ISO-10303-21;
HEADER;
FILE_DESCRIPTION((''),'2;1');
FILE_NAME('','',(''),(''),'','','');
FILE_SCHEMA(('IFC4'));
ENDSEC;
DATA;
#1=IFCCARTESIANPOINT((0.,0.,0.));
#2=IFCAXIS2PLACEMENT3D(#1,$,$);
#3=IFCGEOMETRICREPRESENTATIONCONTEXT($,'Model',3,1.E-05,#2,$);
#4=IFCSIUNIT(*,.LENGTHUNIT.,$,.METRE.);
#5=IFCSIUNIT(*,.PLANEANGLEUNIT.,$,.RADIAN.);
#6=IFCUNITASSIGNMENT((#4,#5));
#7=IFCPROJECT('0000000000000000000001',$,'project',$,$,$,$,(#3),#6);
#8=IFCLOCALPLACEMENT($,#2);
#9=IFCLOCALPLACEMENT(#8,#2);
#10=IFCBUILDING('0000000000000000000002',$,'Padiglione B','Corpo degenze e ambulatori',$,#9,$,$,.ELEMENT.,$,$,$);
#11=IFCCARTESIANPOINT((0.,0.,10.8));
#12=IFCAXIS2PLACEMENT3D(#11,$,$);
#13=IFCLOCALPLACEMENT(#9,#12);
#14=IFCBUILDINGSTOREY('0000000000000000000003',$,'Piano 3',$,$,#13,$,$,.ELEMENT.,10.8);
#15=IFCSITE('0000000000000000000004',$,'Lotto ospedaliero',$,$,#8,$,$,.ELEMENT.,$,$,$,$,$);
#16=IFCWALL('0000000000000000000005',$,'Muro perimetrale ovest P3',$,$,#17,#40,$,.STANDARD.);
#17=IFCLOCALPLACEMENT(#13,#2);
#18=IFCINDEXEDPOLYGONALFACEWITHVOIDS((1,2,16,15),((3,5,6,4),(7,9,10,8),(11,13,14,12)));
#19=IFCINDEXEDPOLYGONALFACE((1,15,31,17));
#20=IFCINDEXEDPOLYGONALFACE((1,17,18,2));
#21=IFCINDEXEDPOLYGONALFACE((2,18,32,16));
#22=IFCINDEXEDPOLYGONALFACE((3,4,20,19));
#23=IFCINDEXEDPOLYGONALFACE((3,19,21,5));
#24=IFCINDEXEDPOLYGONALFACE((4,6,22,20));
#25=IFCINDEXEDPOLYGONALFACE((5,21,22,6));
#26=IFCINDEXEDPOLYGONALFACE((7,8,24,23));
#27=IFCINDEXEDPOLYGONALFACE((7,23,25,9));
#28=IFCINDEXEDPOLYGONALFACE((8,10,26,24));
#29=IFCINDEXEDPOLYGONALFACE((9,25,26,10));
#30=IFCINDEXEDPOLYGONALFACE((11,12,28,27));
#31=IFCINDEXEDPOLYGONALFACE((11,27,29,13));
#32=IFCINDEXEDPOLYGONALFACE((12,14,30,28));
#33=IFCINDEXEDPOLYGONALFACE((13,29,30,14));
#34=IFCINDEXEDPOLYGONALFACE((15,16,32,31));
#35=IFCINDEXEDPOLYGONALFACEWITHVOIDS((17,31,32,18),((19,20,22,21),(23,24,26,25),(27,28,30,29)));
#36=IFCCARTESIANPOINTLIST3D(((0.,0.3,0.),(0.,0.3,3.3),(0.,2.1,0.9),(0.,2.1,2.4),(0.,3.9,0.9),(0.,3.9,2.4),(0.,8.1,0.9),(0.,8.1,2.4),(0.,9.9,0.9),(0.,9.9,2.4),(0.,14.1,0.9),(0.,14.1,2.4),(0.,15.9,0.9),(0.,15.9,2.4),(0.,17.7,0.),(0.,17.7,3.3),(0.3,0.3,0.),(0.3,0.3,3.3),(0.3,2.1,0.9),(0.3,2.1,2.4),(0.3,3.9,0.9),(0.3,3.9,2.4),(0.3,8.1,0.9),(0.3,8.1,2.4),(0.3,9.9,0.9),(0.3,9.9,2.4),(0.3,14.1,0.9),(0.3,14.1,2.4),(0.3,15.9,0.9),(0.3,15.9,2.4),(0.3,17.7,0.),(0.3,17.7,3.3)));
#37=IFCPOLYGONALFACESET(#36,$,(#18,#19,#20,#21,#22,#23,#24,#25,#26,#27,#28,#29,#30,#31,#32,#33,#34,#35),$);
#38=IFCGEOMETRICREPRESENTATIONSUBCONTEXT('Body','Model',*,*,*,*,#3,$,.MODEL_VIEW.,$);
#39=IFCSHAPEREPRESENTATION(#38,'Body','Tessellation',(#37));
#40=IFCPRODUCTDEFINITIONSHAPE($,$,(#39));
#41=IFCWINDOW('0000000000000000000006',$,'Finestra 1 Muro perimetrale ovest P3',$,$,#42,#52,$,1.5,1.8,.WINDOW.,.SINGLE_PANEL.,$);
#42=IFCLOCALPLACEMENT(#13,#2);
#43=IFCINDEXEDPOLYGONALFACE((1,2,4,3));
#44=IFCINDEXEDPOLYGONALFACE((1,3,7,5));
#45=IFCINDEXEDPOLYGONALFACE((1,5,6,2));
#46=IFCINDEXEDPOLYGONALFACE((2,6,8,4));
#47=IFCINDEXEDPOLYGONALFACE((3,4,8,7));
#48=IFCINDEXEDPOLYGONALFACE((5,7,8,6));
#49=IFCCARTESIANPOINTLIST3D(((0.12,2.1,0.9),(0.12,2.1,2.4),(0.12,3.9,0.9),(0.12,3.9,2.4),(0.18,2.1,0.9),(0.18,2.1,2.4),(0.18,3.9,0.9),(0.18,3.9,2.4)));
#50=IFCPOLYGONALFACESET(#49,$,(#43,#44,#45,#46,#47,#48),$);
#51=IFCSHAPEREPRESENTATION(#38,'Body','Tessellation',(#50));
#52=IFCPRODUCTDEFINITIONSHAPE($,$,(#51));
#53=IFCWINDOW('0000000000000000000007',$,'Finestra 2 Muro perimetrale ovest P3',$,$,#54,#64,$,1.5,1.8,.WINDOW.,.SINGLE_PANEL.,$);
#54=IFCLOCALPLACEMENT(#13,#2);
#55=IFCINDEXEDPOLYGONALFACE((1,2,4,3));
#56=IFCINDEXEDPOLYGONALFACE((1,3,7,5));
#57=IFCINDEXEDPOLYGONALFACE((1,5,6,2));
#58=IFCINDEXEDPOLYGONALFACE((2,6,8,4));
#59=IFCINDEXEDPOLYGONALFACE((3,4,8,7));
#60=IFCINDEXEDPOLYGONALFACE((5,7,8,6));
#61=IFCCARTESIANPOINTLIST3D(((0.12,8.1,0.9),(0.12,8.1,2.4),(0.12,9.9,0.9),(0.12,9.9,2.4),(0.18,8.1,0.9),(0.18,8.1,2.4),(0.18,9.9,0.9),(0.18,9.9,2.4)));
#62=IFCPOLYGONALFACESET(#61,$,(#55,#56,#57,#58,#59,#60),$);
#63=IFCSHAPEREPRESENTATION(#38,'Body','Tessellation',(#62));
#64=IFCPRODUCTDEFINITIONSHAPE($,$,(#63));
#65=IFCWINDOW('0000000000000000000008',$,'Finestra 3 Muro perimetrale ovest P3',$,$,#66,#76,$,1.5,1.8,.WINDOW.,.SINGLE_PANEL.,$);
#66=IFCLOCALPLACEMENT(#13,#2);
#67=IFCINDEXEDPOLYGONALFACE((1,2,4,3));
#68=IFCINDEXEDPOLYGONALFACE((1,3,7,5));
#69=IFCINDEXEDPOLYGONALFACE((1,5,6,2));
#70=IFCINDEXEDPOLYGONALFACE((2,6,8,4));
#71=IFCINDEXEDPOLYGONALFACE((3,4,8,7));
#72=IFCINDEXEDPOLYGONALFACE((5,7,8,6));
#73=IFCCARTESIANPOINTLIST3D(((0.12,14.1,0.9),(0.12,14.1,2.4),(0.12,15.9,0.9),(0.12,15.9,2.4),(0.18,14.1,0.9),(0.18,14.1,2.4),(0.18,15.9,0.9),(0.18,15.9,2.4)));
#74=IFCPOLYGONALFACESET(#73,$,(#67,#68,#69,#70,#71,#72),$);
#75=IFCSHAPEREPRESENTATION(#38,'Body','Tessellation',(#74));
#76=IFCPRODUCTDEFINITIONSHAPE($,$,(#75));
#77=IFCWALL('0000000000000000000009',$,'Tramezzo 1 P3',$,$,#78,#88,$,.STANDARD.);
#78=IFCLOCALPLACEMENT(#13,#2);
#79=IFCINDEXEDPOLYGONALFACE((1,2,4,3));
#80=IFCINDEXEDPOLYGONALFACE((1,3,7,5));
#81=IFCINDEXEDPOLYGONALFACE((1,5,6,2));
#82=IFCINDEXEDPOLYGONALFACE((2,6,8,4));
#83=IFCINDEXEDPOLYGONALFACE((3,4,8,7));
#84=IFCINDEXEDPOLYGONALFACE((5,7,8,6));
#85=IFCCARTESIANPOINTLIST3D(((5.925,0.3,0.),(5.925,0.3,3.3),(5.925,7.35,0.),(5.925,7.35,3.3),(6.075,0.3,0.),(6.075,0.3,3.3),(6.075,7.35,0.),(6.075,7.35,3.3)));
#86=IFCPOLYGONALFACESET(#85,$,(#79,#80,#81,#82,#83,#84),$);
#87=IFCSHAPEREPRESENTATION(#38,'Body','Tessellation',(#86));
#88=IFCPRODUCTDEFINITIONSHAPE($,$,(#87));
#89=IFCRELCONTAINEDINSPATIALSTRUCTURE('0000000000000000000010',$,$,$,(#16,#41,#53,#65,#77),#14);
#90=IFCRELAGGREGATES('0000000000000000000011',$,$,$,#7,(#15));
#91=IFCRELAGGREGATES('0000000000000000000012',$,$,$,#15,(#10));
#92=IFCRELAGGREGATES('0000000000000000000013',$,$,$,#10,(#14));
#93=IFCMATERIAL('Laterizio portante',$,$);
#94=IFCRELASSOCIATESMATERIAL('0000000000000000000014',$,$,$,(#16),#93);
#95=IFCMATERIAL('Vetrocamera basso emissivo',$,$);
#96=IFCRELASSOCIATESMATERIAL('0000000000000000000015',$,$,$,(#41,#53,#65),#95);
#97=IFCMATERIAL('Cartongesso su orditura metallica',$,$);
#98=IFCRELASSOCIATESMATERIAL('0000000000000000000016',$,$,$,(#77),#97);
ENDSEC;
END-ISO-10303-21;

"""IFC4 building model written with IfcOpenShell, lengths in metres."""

from ifc_helpers import new_model, si_unit, frame, frame_2d, origin, place, context, subcontext, project, spatial, rectangle, extrude, material, element, fill, save


model = new_model("IFC4")

# Units and contexts
model_context = context("Model", 3, precision=1e-05, world=origin())
body_context = subcontext(model_context, "Body", "Model", "MODEL_VIEW")
ifc_project = project(units=[si_unit("LENGTHUNIT", "METRE"), si_unit("PLANEANGLEUNIT", "RADIAN")], contexts=[model_context])

# Site, building, storey
site_placement = place(None, origin())
site = spatial("IfcSite", under=ifc_project, at=site_placement, Name="Lotto ospedaliero", CompositionType="ELEMENT")
building_placement = place(site_placement, origin())
building = spatial("IfcBuilding", under=site, at=building_placement, Name="Padiglione B", Description="Corpo degenze e ambulatori", CompositionType="ELEMENT")
storey_placement = place(building_placement, frame((0.0, 0.0, 10.8)))
storey = spatial("IfcBuildingStorey", under=building, at=storey_placement, Name="Piano 3", CompositionType="ELEMENT", Elevation=10.8)

# Wall, openings, windows
ifc_material_1 = material(Name="Laterizio portante")
ifc_material_2 = material(Name="Vetrocamera basso emissivo")
wall_1_placement = place(storey_placement, frame((0.0, 0.3, 0.0)))
wall_1 = element("IfcWall", 1, at=wall_1_placement, inside=storey, material=ifc_material_1, Name="Muro perimetrale ovest P3", PredefinedType="STANDARD", context=body_context, shape_type="SweptSolid", body=[
    extrude(rectangle(XDim=0.3, YDim=17.4, at=frame_2d((0.15, 8.7))), origin(), (0.0, 0.0, 1.0), 3.3),
])
opening_1_placement = place(wall_1_placement, frame((-0.1, 1.8, 0.9)))
opening_1 = element("IfcOpeningElement", 2, at=opening_1_placement, cuts=wall_1, PredefinedType="OPENING", context=body_context, shape_type="SweptSolid", body=[
    extrude(rectangle(XDim=0.5, YDim=1.8, at=frame_2d((0.25, 0.9))), origin(), (0.0, 0.0, 1.0), 1.5),
])
opening_2_placement = place(wall_1_placement, frame((-0.1, 7.8, 0.9)))
opening_2 = element("IfcOpeningElement", 3, at=opening_2_placement, cuts=wall_1, PredefinedType="OPENING", context=body_context, shape_type="SweptSolid", body=[
    extrude(rectangle(XDim=0.5, YDim=1.8, at=frame_2d((0.25, 0.9))), origin(), (0.0, 0.0, 1.0), 1.5),
])
opening_3_placement = place(wall_1_placement, frame((-0.1, 13.8, 0.9)))
opening_3 = element("IfcOpeningElement", 4, at=opening_3_placement, cuts=wall_1, PredefinedType="OPENING", context=body_context, shape_type="SweptSolid", body=[
    extrude(rectangle(XDim=0.5, YDim=1.8, at=frame_2d((0.25, 0.9))), origin(), (0.0, 0.0, 1.0), 1.5),
])
window_1_placement = place(wall_1_placement, frame((0.12, 1.8, 0.9)))
window_1 = element("IfcWindow", 5, at=window_1_placement, inside=storey, material=ifc_material_2, Name="Finestra 1 Muro perimetrale ovest P3", OverallHeight=1.5, OverallWidth=1.8, PartitioningType="SINGLE_PANEL", PredefinedType="WINDOW", context=body_context, shape_type="SweptSolid", body=[
    extrude(rectangle(XDim=0.06, YDim=1.8, at=frame_2d((0.03, 0.9))), origin(), (0.0, 0.0, 1.0), 1.5),
])
fill(opening_1, window_1)
window_2_placement = place(wall_1_placement, frame((0.12, 7.8, 0.9)))
window_2 = element("IfcWindow", 6, at=window_2_placement, inside=storey, material=ifc_material_2, Name="Finestra 2 Muro perimetrale ovest P3", OverallHeight=1.5, OverallWidth=1.8, PartitioningType="SINGLE_PANEL", PredefinedType="WINDOW", context=body_context, shape_type="SweptSolid", body=[
    extrude(rectangle(XDim=0.06, YDim=1.8, at=frame_2d((0.03, 0.9))), origin(), (0.0, 0.0, 1.0), 1.5),
])
fill(opening_2, window_2)
window_3_placement = place(wall_1_placement, frame((0.12, 13.8, 0.9)))
window_3 = element("IfcWindow", 7, at=window_3_placement, inside=storey, material=ifc_material_2, Name="Finestra 3 Muro perimetrale ovest P3", OverallHeight=1.5, OverallWidth=1.8, PartitioningType="SINGLE_PANEL", PredefinedType="WINDOW", context=body_context, shape_type="SweptSolid", body=[
    extrude(rectangle(XDim=0.06, YDim=1.8, at=frame_2d((0.03, 0.9))), origin(), (0.0, 0.0, 1.0), 1.5),
])
fill(opening_3, window_3)

# Wall
ifc_material_3 = material(Name="Cartongesso su orditura metallica")
wall_2_placement = place(storey_placement, frame((5.925, 0.3, 0.0)))
element("IfcWall", 8, at=wall_2_placement, inside=storey, material=ifc_material_3, Name="Tramezzo 1 P3", PredefinedType="STANDARD", context=body_context, shape_type="SweptSolid", body=[
    extrude(rectangle(XDim=0.15, YDim=7.05, at=frame_2d((0.075, 3.525))), origin(), (0.0, 0.0, 1.0), 3.3),
])

save(model, "model.ifc")
